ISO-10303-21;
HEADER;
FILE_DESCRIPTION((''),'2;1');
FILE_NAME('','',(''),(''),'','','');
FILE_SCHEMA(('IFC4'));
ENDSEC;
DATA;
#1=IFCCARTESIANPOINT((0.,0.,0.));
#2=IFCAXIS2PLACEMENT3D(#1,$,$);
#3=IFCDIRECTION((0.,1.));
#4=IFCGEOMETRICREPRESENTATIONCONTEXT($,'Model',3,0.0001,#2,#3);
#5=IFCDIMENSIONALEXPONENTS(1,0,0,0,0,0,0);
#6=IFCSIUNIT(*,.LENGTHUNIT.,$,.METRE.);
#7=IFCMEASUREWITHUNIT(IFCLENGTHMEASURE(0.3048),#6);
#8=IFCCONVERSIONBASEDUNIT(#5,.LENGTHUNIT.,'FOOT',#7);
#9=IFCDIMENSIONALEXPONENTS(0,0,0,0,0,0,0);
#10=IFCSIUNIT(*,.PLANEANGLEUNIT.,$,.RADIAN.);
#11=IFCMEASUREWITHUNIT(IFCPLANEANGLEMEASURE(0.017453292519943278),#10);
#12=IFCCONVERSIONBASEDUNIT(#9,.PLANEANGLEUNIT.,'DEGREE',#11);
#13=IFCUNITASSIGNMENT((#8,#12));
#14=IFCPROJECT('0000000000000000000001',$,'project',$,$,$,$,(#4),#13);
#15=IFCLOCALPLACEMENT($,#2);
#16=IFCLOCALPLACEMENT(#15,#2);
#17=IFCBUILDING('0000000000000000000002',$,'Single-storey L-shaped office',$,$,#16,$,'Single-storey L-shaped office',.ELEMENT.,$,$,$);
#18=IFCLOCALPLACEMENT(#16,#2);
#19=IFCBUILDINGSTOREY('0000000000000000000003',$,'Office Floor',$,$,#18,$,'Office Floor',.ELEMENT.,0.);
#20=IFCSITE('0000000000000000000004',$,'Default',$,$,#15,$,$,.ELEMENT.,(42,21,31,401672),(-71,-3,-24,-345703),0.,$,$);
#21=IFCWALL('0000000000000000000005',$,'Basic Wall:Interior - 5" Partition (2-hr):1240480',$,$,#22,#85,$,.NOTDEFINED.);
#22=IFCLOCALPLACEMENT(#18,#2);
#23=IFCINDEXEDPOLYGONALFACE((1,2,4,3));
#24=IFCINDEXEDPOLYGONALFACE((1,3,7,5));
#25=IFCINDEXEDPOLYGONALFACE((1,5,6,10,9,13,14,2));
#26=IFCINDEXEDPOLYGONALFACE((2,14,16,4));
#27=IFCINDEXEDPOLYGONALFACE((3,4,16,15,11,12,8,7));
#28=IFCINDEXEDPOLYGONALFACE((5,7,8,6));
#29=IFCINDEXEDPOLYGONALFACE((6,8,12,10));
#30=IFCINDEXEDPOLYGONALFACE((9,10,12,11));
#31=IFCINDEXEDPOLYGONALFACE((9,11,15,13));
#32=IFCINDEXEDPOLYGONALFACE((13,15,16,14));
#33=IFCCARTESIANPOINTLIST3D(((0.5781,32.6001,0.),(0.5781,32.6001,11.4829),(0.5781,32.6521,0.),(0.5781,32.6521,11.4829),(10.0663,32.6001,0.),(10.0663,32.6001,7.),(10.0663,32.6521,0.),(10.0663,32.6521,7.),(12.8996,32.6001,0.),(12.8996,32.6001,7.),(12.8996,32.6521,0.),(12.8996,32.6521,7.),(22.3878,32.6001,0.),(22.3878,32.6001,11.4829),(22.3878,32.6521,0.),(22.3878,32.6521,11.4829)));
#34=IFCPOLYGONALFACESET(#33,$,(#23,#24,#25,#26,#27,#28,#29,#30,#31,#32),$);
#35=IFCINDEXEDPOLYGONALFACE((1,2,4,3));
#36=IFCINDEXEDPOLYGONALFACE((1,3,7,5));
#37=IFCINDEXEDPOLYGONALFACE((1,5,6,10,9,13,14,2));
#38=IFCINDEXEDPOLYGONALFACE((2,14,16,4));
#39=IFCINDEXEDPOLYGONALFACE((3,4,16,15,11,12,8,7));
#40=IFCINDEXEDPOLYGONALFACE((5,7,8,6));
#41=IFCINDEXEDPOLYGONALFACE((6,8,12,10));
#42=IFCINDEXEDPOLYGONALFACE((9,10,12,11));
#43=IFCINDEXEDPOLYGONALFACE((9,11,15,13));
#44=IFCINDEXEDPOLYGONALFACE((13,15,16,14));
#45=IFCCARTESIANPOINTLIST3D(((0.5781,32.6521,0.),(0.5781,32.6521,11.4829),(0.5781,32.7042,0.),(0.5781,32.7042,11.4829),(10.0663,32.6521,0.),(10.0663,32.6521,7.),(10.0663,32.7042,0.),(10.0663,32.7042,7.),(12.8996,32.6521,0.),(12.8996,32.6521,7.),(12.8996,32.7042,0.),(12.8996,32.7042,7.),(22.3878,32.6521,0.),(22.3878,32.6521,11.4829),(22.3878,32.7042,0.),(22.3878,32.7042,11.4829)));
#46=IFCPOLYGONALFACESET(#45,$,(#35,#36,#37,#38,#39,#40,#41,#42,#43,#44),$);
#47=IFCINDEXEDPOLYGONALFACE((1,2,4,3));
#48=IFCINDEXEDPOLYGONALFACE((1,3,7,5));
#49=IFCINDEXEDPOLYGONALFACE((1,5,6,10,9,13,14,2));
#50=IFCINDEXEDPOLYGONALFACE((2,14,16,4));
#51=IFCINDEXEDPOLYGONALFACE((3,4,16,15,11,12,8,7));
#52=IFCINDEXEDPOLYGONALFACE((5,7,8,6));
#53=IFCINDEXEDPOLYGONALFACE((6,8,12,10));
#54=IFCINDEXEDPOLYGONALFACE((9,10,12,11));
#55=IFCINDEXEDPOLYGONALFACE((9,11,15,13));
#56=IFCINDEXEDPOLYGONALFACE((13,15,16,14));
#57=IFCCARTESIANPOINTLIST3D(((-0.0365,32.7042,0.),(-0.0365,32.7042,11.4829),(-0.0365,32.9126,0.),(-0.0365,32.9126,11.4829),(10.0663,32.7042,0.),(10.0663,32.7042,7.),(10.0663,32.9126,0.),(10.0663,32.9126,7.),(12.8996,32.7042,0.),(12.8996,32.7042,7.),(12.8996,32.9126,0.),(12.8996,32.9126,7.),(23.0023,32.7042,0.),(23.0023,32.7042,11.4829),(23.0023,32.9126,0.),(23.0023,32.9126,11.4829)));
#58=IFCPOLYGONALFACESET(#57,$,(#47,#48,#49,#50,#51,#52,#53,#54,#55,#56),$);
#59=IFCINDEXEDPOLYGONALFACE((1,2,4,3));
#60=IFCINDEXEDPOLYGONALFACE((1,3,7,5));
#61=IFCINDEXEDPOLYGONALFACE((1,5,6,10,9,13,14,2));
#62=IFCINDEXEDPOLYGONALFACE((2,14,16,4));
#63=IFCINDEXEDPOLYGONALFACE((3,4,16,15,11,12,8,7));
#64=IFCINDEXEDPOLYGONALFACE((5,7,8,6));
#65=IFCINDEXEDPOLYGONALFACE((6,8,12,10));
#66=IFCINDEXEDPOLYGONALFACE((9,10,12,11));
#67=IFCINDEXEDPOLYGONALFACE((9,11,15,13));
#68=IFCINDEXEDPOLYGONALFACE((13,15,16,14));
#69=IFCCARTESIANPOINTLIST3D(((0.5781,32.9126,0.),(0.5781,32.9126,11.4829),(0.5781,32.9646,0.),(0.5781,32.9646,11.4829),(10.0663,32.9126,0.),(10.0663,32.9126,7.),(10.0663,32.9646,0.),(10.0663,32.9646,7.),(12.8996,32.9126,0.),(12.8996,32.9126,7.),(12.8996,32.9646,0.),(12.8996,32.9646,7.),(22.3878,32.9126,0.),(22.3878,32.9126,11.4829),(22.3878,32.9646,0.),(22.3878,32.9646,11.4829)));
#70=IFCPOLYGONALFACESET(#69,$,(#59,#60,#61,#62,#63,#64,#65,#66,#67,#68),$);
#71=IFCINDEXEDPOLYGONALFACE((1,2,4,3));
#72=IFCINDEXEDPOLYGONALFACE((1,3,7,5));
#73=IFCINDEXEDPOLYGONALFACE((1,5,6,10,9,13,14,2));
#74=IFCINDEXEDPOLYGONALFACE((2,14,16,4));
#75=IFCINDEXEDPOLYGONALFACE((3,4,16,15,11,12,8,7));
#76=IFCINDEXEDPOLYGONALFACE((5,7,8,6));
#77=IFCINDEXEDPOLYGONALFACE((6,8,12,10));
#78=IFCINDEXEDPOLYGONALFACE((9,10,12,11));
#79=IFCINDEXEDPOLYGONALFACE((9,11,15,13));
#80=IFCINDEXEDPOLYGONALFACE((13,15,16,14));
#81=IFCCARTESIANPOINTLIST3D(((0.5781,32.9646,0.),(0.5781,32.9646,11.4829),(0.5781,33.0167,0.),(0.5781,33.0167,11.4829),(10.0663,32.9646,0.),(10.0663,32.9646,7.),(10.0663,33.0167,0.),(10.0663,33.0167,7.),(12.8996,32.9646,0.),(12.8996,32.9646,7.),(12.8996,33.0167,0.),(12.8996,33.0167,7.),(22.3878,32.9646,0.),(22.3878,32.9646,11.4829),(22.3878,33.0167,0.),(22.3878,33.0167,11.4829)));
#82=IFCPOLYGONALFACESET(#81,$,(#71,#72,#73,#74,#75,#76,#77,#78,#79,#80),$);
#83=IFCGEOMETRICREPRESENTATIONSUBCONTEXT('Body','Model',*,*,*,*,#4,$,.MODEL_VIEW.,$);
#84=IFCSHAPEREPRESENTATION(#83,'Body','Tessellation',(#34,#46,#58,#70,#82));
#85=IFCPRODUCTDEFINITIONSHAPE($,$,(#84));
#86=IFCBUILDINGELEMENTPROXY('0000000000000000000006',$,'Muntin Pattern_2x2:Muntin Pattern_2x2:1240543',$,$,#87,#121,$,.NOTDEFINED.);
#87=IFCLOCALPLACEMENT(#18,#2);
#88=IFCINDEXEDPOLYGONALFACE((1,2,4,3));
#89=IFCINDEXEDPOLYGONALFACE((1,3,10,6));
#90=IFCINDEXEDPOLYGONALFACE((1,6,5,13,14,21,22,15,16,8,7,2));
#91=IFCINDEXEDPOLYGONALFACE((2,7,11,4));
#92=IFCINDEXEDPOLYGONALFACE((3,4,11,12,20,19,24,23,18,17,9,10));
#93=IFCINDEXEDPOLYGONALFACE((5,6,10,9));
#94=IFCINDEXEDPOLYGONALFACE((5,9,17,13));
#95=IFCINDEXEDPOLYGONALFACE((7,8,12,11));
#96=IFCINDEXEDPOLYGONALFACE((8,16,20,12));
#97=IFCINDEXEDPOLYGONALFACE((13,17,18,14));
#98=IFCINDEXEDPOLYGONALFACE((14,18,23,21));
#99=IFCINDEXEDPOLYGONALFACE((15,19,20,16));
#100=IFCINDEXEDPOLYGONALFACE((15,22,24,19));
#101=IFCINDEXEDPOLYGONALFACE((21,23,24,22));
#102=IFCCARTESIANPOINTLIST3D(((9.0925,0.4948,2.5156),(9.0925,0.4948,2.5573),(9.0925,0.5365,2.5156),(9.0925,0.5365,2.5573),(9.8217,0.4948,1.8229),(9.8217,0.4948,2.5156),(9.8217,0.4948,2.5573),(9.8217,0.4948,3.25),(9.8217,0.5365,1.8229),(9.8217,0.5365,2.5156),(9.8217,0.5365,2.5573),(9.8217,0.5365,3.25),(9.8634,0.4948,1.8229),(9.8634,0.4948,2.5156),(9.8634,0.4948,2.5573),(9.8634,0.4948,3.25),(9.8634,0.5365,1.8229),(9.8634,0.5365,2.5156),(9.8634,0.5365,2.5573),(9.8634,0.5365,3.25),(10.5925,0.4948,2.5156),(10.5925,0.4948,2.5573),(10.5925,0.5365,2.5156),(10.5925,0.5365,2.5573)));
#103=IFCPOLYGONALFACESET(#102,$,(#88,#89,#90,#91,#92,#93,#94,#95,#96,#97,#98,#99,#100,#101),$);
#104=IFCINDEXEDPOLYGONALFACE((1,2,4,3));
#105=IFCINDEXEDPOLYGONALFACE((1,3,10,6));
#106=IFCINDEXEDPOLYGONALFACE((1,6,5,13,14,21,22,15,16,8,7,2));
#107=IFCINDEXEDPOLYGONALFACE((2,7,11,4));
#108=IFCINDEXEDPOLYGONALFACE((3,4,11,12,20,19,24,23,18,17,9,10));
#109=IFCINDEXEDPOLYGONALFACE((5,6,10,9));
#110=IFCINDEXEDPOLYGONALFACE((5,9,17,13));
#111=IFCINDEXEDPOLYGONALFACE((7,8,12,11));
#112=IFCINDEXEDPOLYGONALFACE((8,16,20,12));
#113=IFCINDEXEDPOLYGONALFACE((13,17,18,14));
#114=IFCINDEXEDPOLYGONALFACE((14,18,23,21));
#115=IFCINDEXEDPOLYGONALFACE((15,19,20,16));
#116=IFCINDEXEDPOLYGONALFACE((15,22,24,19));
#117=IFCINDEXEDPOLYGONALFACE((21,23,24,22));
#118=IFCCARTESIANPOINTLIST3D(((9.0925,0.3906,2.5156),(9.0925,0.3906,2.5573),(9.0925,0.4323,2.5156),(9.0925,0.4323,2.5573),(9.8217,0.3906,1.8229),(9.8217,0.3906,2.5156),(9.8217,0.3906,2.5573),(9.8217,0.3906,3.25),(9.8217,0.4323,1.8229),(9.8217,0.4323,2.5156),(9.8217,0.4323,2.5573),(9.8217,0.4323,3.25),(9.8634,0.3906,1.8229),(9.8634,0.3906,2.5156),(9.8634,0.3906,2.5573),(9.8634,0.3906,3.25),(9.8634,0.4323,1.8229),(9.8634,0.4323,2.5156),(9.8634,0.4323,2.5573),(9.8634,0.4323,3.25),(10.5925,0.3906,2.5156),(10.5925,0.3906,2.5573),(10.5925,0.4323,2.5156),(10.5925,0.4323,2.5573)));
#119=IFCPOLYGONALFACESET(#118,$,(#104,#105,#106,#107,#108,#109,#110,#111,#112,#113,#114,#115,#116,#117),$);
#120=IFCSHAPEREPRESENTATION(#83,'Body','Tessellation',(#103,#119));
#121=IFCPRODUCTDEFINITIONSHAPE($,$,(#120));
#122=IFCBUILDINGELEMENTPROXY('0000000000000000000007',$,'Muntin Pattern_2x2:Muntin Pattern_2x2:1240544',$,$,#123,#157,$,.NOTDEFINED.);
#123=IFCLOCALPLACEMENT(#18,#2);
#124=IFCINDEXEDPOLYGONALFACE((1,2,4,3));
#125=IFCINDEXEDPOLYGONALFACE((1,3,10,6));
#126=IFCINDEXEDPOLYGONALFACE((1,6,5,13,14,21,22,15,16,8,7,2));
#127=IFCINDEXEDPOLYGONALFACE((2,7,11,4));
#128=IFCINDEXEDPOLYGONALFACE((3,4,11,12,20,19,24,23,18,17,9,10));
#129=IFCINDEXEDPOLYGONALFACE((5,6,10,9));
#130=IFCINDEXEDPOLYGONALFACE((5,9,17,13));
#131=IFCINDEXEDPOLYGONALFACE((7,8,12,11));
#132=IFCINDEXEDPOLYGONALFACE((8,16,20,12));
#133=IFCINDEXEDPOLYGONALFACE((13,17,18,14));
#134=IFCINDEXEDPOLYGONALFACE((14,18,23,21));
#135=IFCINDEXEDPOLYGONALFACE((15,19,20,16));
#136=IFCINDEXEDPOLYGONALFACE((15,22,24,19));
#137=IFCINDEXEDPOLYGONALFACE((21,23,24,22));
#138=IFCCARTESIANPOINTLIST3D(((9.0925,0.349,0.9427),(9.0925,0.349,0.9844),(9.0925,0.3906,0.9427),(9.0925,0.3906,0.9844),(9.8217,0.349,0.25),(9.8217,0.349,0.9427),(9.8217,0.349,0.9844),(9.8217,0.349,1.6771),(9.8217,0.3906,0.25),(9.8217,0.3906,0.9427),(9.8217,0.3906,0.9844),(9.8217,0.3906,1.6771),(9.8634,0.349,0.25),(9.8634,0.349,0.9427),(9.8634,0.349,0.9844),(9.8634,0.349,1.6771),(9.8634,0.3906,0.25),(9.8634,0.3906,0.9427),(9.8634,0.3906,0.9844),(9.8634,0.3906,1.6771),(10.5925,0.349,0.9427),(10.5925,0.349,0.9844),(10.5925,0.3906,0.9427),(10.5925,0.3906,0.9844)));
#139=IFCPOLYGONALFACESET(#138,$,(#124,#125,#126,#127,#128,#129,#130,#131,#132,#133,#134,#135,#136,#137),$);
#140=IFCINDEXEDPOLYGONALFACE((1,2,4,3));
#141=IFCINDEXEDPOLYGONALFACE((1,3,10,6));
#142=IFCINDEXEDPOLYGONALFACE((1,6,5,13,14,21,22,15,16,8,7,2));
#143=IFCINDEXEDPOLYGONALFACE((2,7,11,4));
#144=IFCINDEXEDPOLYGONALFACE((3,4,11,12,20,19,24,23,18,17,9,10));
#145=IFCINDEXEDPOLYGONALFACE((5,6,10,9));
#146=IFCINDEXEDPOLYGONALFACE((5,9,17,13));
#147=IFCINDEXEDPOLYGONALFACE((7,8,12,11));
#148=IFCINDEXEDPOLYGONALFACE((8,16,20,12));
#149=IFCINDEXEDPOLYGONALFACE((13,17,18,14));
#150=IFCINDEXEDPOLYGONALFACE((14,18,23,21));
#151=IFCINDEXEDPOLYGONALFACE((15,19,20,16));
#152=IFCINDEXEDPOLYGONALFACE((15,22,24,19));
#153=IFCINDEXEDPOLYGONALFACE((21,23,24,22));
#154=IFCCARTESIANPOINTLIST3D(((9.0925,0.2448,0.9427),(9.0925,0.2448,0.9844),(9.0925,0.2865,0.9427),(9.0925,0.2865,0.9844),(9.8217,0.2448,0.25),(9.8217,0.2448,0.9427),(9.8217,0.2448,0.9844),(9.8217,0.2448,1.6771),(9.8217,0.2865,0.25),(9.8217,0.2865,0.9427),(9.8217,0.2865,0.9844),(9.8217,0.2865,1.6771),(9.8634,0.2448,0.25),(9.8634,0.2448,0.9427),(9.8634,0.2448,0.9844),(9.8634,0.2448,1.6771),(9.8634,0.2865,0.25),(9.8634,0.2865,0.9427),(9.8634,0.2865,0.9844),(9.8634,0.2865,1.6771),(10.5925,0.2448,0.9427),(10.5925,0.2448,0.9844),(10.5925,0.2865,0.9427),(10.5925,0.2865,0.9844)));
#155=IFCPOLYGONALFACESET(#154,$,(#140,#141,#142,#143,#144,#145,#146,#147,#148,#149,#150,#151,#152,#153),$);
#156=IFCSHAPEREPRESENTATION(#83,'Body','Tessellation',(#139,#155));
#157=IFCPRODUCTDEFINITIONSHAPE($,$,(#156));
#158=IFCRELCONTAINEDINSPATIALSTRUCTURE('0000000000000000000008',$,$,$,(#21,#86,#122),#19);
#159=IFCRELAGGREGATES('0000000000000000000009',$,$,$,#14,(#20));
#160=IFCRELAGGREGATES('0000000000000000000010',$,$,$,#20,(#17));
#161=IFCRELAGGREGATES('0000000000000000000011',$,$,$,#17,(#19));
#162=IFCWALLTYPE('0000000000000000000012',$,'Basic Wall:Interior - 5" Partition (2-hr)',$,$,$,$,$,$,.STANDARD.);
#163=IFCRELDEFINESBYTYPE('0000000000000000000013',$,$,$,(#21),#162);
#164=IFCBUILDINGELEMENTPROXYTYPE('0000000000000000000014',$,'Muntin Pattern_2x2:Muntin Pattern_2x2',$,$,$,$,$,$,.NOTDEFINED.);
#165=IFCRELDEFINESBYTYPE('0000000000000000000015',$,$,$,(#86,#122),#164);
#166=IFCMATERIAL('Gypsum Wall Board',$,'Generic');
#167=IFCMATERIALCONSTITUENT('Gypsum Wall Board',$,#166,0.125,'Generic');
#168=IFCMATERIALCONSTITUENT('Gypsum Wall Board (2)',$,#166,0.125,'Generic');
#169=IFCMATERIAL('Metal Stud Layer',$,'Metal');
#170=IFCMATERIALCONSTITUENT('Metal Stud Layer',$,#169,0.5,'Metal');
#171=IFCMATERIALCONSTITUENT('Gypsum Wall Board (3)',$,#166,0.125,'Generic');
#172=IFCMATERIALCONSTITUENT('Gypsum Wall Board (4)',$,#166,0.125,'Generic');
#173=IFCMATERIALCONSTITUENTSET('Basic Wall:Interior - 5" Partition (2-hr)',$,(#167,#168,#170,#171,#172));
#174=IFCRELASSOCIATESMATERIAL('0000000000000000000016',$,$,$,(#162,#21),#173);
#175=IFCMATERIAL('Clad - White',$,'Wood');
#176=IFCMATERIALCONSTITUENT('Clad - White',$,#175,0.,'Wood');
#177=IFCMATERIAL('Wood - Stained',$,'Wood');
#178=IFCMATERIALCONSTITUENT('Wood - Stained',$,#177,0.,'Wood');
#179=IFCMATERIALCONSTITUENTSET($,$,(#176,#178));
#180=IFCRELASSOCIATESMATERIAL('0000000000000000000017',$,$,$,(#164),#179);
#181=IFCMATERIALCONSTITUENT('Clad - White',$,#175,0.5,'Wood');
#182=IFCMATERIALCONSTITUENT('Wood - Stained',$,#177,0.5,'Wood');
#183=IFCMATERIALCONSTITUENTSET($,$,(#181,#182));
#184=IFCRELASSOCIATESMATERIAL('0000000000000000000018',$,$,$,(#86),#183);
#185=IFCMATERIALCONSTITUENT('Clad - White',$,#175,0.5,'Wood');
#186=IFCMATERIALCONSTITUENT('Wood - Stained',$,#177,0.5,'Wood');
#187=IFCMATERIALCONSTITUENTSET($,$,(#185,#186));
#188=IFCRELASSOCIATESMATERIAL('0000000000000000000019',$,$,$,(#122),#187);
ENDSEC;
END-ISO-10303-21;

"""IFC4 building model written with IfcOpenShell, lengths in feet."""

from ifc_helpers import new_model, entity, si_unit, converted_unit, direction, frame, origin, place, context, subcontext, project, spatial, indexed_curve, outline, extrude, source, transform, mapped, material, constituent, constituent_set, type_object, type_shapes, element, save


model = new_model("IFC4")

# Units and contexts
model_context = context("Model", 3, precision=0.0001, world=origin(), true_north=direction((0.0, 1.0)))
body_context = subcontext(model_context, "Body", "Model", "MODEL_VIEW")
ifc_project = project(units=[converted_unit("LENGTHUNIT", "FOOT", entity("IfcLengthMeasure", 0.3048), si_unit("LENGTHUNIT", "METRE"), dimensions=[1, 0, 0, 0, 0, 0, 0]), converted_unit("PLANEANGLEUNIT", "DEGREE", entity("IfcPlaneAngleMeasure", 0.017453292519943278), si_unit("PLANEANGLEUNIT", "RADIAN"), dimensions=[0, 0, 0, 0, 0, 0, 0])], contexts=[model_context])

# Site, building, storey
site_placement = place(None, origin())
site = spatial("IfcSite", under=ifc_project, at=site_placement, Name="Default", CompositionType="ELEMENT", RefLatitude=(42, 21, 31, 401672), RefLongitude=(-71, -3, -24, -345703), RefElevation=0.0)
building_placement = place(site_placement, origin())
building = spatial("IfcBuilding", under=site, at=building_placement, Name="Single-storey L-shaped office", LongName="Single-storey L-shaped office", CompositionType="ELEMENT")
storey_placement = place(building_placement, origin())
storey = spatial("IfcBuildingStorey", under=building, at=storey_placement, Name="Office Floor", LongName="Office Floor", CompositionType="ELEMENT", Elevation=0.0)

# Shared definitions
ifc_material_1 = material(Name="Metal Stud Layer", Category="Metal")
ifc_material_2 = material(Name="Gypsum Wall Board", Category="Generic")
ifc_material_3 = material(Name="Wood - Stained", Category="Wood")

# Wall, opening
ifc_constituent_1 = constituent(ifc_material_2, Name="Gypsum Wall Board", Category="Generic", fraction=0.125)
ifc_constituent_2 = constituent(ifc_material_2, Name="Gypsum Wall Board (2)", Category="Generic", fraction=0.125)
ifc_constituent_3 = constituent(ifc_material_1, Name="Metal Stud Layer", Category="Metal", fraction=0.5)
ifc_constituent_4 = constituent(ifc_material_2, Name="Gypsum Wall Board (3)", Category="Generic", fraction=0.125)
ifc_constituent_5 = constituent(ifc_material_2, Name="Gypsum Wall Board (4)", Category="Generic", fraction=0.125)
ifc_constituent_set_1 = constituent_set(constituents=[ifc_constituent_1, ifc_constituent_2, ifc_constituent_3, ifc_constituent_4, ifc_constituent_5], Name="Basic Wall:Interior - 5\" Partition (2-hr)")
wall_type_1 = type_object("IfcWallType", Name="Basic Wall:Interior - 5\" Partition (2-hr)", PredefinedType="STANDARD", material=ifc_constituent_set_1)
wall_1_placement = place(storey_placement, frame((0.5781, 32.8084, 0.0)))
wall_1 = element("IfcWall", 1, at=wall_1_placement, inside=storey, type_object=wall_type_1, material=ifc_constituent_set_1, Name="Basic Wall:Interior - 5\" Partition (2-hr):1240480", PredefinedType="NOTDEFINED", context=body_context, shape_type="SweptSolid", body=[
    extrude(outline(indexed_curve([(-6.8622, -10.9048), (4.6207, -10.9048), (4.6207, -1.4167), (-2.3793, -1.4167), (-2.3793, 1.4167), (4.6207, 1.4167), (4.6207, 10.9048), (-6.8622, 10.9048), (-6.8622, -10.9048)], self_intersect=False)), frame((10.9048, -0.2083, 4.6207), z_axis=(0.0, 1.0, 0.0), x_axis=(0.0, 0.0, -1.0)), (0.0, 0.0, 1.0), 0.0521),
    extrude(outline(indexed_curve([(-4.6207, -10.9048), (6.8622, -10.9048), (6.8622, 10.9048), (-4.6207, 10.9048), (-4.6207, 1.4167), (2.3793, 1.4167), (2.3793, -1.4167), (-4.6207, -1.4167), (-4.6207, -10.9048)], self_intersect=False)), frame((10.9048, -0.1562, 4.6207), z_axis=(0.0, 1.0, 0.0), x_axis=(0.0, 0.0, 1.0)), (0.0, 0.0, 1.0), 0.0521),
    extrude(outline(indexed_curve([(-4.6207, -11.5194), (6.8622, -11.5194), (6.8622, 11.5194), (-4.6207, 11.5194), (-4.6207, 1.4167), (2.3793, 1.4167), (2.3793, -1.4167), (-4.6207, -1.4167), (-4.6207, -11.5194)], self_intersect=False)), frame((10.9048, -0.1042, 4.6207), z_axis=(0.0, 1.0, 0.0), x_axis=(0.0, 0.0, 1.0)), (0.0, 0.0, 1.0), 0.2083),
    extrude(outline(indexed_curve([(-4.6207, -10.9048), (6.8622, -10.9048), (6.8622, 10.9048), (-4.6207, 10.9048), (-4.6207, 1.4167), (2.3793, 1.4167), (2.3793, -1.4167), (-4.6207, -1.4167), (-4.6207, -10.9048)], self_intersect=False)), frame((10.9048, 0.1042, 4.6207), z_axis=(0.0, 1.0, 0.0), x_axis=(0.0, 0.0, 1.0)), (0.0, 0.0, 1.0), 0.0521),
    extrude(outline(indexed_curve([(-4.6207, -10.9048), (6.8622, -10.9048), (6.8622, 10.9048), (-4.6207, 10.9048), (-4.6207, 1.4167), (2.3793, 1.4167), (2.3793, -1.4167), (-4.6207, -1.4167), (-4.6207, -10.9048)], self_intersect=False)), frame((10.9048, 0.1562, 4.6207), z_axis=(0.0, 1.0, 0.0), x_axis=(0.0, 0.0, 1.0)), (0.0, 0.0, 1.0), 0.0521),
])
opening_1_placement = place(wall_1_placement, frame((9.4881, -0.2083, 0.0)))
element("IfcOpeningElement", 2, at=opening_1_placement, cuts=wall_1, PredefinedType="OPENING", context=body_context, shape_type="SweptSolid", body=[
    extrude(outline(indexed_curve([(0.0, 2.8333), (0.0, 0.0), (7.0, 0.0), (7.0, 2.8333), (0.0, 2.8333)], self_intersect=False)), frame((0.0, 0.0, 0.0), z_axis=(0.0, 1.0, 0.0), x_axis=(0.0, 0.0, 1.0)), (0.0, 0.0, 1.0), 0.4167),
])

# Building element proxies
ifc_material_4 = material(Name="Clad - White", Category="Wood")
ifc_constituent_6 = constituent(ifc_material_4, Name="Clad - White", Category="Wood", fraction=0.5)
ifc_constituent_7 = constituent(ifc_material_3, Name="Wood - Stained", Category="Wood", fraction=0.5)
ifc_constituent_set_2 = constituent_set(constituents=[ifc_constituent_6, ifc_constituent_7])
ifc_constituent_8 = constituent(ifc_material_4, Name="Clad - White", Category="Wood", fraction=0.0)
ifc_constituent_9 = constituent(ifc_material_3, Name="Wood - Stained", Category="Wood", fraction=0.0)
ifc_constituent_set_3 = constituent_set(constituents=[ifc_constituent_8, ifc_constituent_9])
building_element_proxy_type_1 = type_object("IfcBuildingElementProxyType", Name="Muntin Pattern_2x2:Muntin Pattern_2x2", PredefinedType="NOTDEFINED", material=ifc_constituent_set_3)
shared_shape_1 = source(origin(), body_context, "Body", "SweptSolid", [
    extrude(outline(indexed_curve([(0.0208, -0.0208), (0.7135, -0.0208), (0.7135, 0.0208), (0.0208, 0.0208), (0.0208, 0.75), (-0.0208, 0.75), (-0.0208, 0.0208), (-0.7135, 0.0208), (-0.7135, -0.0208), (-0.0208, -0.0208), (-0.0208, -0.75), (0.0208, -0.75), (0.0208, -0.0208)], self_intersect=False)), frame((0.0, 0.0312, 0.7135), z_axis=(0.0, 1.0, 0.0), x_axis=(0.0, 0.0, 1.0)), (0.0, 0.0, 1.0), 0.0417),
    extrude(outline(indexed_curve([(0.0208, -0.0208), (0.7135, -0.0208), (0.7135, 0.0208), (0.0208, 0.0208), (0.0208, 0.75), (-0.0208, 0.75), (-0.0208, 0.0208), (-0.7135, 0.0208), (-0.7135, -0.0208), (-0.0208, -0.0208), (-0.0208, -0.75), (0.0208, -0.75), (0.0208, -0.0208)], self_intersect=False)), frame((0.0, -0.0729, 0.7135), z_axis=(0.0, 1.0, 0.0), x_axis=(0.0, 0.0, 1.0)), (0.0, 0.0, 1.0), 0.0417),
])
type_shapes(building_element_proxy_type_1, [shared_shape_1])
proxy_1_placement = place(storey_placement, frame((9.8425, 0.4635, 1.8229)))
element("IfcBuildingElementProxy", 3, at=proxy_1_placement, inside=storey, type_object=building_element_proxy_type_1, material=ifc_constituent_set_2, Name="Muntin Pattern_2x2:Muntin Pattern_2x2:1240543", PredefinedType="NOTDEFINED", context=body_context, shape_type="MappedRepresentation", body=[
    mapped(shared_shape_1, transform((0.0, 0.0, 0.0), scale=1.0)),
])
ifc_constituent_10 = constituent(ifc_material_4, Name="Clad - White", Category="Wood", fraction=0.5)
ifc_constituent_11 = constituent(ifc_material_3, Name="Wood - Stained", Category="Wood", fraction=0.5)
ifc_constituent_set_4 = constituent_set(constituents=[ifc_constituent_10, ifc_constituent_11])
proxy_2_placement = place(storey_placement, frame((9.8425, 0.3177, 0.25)))
element("IfcBuildingElementProxy", 4, at=proxy_2_placement, inside=storey, type_object=building_element_proxy_type_1, material=ifc_constituent_set_4, Name="Muntin Pattern_2x2:Muntin Pattern_2x2:1240544", PredefinedType="NOTDEFINED", context=body_context, shape_type="MappedRepresentation", body=[
    mapped(shared_shape_1, transform((0.0, 0.0, 0.0), scale=1.0)),
])

save(model, "model.ifc")
